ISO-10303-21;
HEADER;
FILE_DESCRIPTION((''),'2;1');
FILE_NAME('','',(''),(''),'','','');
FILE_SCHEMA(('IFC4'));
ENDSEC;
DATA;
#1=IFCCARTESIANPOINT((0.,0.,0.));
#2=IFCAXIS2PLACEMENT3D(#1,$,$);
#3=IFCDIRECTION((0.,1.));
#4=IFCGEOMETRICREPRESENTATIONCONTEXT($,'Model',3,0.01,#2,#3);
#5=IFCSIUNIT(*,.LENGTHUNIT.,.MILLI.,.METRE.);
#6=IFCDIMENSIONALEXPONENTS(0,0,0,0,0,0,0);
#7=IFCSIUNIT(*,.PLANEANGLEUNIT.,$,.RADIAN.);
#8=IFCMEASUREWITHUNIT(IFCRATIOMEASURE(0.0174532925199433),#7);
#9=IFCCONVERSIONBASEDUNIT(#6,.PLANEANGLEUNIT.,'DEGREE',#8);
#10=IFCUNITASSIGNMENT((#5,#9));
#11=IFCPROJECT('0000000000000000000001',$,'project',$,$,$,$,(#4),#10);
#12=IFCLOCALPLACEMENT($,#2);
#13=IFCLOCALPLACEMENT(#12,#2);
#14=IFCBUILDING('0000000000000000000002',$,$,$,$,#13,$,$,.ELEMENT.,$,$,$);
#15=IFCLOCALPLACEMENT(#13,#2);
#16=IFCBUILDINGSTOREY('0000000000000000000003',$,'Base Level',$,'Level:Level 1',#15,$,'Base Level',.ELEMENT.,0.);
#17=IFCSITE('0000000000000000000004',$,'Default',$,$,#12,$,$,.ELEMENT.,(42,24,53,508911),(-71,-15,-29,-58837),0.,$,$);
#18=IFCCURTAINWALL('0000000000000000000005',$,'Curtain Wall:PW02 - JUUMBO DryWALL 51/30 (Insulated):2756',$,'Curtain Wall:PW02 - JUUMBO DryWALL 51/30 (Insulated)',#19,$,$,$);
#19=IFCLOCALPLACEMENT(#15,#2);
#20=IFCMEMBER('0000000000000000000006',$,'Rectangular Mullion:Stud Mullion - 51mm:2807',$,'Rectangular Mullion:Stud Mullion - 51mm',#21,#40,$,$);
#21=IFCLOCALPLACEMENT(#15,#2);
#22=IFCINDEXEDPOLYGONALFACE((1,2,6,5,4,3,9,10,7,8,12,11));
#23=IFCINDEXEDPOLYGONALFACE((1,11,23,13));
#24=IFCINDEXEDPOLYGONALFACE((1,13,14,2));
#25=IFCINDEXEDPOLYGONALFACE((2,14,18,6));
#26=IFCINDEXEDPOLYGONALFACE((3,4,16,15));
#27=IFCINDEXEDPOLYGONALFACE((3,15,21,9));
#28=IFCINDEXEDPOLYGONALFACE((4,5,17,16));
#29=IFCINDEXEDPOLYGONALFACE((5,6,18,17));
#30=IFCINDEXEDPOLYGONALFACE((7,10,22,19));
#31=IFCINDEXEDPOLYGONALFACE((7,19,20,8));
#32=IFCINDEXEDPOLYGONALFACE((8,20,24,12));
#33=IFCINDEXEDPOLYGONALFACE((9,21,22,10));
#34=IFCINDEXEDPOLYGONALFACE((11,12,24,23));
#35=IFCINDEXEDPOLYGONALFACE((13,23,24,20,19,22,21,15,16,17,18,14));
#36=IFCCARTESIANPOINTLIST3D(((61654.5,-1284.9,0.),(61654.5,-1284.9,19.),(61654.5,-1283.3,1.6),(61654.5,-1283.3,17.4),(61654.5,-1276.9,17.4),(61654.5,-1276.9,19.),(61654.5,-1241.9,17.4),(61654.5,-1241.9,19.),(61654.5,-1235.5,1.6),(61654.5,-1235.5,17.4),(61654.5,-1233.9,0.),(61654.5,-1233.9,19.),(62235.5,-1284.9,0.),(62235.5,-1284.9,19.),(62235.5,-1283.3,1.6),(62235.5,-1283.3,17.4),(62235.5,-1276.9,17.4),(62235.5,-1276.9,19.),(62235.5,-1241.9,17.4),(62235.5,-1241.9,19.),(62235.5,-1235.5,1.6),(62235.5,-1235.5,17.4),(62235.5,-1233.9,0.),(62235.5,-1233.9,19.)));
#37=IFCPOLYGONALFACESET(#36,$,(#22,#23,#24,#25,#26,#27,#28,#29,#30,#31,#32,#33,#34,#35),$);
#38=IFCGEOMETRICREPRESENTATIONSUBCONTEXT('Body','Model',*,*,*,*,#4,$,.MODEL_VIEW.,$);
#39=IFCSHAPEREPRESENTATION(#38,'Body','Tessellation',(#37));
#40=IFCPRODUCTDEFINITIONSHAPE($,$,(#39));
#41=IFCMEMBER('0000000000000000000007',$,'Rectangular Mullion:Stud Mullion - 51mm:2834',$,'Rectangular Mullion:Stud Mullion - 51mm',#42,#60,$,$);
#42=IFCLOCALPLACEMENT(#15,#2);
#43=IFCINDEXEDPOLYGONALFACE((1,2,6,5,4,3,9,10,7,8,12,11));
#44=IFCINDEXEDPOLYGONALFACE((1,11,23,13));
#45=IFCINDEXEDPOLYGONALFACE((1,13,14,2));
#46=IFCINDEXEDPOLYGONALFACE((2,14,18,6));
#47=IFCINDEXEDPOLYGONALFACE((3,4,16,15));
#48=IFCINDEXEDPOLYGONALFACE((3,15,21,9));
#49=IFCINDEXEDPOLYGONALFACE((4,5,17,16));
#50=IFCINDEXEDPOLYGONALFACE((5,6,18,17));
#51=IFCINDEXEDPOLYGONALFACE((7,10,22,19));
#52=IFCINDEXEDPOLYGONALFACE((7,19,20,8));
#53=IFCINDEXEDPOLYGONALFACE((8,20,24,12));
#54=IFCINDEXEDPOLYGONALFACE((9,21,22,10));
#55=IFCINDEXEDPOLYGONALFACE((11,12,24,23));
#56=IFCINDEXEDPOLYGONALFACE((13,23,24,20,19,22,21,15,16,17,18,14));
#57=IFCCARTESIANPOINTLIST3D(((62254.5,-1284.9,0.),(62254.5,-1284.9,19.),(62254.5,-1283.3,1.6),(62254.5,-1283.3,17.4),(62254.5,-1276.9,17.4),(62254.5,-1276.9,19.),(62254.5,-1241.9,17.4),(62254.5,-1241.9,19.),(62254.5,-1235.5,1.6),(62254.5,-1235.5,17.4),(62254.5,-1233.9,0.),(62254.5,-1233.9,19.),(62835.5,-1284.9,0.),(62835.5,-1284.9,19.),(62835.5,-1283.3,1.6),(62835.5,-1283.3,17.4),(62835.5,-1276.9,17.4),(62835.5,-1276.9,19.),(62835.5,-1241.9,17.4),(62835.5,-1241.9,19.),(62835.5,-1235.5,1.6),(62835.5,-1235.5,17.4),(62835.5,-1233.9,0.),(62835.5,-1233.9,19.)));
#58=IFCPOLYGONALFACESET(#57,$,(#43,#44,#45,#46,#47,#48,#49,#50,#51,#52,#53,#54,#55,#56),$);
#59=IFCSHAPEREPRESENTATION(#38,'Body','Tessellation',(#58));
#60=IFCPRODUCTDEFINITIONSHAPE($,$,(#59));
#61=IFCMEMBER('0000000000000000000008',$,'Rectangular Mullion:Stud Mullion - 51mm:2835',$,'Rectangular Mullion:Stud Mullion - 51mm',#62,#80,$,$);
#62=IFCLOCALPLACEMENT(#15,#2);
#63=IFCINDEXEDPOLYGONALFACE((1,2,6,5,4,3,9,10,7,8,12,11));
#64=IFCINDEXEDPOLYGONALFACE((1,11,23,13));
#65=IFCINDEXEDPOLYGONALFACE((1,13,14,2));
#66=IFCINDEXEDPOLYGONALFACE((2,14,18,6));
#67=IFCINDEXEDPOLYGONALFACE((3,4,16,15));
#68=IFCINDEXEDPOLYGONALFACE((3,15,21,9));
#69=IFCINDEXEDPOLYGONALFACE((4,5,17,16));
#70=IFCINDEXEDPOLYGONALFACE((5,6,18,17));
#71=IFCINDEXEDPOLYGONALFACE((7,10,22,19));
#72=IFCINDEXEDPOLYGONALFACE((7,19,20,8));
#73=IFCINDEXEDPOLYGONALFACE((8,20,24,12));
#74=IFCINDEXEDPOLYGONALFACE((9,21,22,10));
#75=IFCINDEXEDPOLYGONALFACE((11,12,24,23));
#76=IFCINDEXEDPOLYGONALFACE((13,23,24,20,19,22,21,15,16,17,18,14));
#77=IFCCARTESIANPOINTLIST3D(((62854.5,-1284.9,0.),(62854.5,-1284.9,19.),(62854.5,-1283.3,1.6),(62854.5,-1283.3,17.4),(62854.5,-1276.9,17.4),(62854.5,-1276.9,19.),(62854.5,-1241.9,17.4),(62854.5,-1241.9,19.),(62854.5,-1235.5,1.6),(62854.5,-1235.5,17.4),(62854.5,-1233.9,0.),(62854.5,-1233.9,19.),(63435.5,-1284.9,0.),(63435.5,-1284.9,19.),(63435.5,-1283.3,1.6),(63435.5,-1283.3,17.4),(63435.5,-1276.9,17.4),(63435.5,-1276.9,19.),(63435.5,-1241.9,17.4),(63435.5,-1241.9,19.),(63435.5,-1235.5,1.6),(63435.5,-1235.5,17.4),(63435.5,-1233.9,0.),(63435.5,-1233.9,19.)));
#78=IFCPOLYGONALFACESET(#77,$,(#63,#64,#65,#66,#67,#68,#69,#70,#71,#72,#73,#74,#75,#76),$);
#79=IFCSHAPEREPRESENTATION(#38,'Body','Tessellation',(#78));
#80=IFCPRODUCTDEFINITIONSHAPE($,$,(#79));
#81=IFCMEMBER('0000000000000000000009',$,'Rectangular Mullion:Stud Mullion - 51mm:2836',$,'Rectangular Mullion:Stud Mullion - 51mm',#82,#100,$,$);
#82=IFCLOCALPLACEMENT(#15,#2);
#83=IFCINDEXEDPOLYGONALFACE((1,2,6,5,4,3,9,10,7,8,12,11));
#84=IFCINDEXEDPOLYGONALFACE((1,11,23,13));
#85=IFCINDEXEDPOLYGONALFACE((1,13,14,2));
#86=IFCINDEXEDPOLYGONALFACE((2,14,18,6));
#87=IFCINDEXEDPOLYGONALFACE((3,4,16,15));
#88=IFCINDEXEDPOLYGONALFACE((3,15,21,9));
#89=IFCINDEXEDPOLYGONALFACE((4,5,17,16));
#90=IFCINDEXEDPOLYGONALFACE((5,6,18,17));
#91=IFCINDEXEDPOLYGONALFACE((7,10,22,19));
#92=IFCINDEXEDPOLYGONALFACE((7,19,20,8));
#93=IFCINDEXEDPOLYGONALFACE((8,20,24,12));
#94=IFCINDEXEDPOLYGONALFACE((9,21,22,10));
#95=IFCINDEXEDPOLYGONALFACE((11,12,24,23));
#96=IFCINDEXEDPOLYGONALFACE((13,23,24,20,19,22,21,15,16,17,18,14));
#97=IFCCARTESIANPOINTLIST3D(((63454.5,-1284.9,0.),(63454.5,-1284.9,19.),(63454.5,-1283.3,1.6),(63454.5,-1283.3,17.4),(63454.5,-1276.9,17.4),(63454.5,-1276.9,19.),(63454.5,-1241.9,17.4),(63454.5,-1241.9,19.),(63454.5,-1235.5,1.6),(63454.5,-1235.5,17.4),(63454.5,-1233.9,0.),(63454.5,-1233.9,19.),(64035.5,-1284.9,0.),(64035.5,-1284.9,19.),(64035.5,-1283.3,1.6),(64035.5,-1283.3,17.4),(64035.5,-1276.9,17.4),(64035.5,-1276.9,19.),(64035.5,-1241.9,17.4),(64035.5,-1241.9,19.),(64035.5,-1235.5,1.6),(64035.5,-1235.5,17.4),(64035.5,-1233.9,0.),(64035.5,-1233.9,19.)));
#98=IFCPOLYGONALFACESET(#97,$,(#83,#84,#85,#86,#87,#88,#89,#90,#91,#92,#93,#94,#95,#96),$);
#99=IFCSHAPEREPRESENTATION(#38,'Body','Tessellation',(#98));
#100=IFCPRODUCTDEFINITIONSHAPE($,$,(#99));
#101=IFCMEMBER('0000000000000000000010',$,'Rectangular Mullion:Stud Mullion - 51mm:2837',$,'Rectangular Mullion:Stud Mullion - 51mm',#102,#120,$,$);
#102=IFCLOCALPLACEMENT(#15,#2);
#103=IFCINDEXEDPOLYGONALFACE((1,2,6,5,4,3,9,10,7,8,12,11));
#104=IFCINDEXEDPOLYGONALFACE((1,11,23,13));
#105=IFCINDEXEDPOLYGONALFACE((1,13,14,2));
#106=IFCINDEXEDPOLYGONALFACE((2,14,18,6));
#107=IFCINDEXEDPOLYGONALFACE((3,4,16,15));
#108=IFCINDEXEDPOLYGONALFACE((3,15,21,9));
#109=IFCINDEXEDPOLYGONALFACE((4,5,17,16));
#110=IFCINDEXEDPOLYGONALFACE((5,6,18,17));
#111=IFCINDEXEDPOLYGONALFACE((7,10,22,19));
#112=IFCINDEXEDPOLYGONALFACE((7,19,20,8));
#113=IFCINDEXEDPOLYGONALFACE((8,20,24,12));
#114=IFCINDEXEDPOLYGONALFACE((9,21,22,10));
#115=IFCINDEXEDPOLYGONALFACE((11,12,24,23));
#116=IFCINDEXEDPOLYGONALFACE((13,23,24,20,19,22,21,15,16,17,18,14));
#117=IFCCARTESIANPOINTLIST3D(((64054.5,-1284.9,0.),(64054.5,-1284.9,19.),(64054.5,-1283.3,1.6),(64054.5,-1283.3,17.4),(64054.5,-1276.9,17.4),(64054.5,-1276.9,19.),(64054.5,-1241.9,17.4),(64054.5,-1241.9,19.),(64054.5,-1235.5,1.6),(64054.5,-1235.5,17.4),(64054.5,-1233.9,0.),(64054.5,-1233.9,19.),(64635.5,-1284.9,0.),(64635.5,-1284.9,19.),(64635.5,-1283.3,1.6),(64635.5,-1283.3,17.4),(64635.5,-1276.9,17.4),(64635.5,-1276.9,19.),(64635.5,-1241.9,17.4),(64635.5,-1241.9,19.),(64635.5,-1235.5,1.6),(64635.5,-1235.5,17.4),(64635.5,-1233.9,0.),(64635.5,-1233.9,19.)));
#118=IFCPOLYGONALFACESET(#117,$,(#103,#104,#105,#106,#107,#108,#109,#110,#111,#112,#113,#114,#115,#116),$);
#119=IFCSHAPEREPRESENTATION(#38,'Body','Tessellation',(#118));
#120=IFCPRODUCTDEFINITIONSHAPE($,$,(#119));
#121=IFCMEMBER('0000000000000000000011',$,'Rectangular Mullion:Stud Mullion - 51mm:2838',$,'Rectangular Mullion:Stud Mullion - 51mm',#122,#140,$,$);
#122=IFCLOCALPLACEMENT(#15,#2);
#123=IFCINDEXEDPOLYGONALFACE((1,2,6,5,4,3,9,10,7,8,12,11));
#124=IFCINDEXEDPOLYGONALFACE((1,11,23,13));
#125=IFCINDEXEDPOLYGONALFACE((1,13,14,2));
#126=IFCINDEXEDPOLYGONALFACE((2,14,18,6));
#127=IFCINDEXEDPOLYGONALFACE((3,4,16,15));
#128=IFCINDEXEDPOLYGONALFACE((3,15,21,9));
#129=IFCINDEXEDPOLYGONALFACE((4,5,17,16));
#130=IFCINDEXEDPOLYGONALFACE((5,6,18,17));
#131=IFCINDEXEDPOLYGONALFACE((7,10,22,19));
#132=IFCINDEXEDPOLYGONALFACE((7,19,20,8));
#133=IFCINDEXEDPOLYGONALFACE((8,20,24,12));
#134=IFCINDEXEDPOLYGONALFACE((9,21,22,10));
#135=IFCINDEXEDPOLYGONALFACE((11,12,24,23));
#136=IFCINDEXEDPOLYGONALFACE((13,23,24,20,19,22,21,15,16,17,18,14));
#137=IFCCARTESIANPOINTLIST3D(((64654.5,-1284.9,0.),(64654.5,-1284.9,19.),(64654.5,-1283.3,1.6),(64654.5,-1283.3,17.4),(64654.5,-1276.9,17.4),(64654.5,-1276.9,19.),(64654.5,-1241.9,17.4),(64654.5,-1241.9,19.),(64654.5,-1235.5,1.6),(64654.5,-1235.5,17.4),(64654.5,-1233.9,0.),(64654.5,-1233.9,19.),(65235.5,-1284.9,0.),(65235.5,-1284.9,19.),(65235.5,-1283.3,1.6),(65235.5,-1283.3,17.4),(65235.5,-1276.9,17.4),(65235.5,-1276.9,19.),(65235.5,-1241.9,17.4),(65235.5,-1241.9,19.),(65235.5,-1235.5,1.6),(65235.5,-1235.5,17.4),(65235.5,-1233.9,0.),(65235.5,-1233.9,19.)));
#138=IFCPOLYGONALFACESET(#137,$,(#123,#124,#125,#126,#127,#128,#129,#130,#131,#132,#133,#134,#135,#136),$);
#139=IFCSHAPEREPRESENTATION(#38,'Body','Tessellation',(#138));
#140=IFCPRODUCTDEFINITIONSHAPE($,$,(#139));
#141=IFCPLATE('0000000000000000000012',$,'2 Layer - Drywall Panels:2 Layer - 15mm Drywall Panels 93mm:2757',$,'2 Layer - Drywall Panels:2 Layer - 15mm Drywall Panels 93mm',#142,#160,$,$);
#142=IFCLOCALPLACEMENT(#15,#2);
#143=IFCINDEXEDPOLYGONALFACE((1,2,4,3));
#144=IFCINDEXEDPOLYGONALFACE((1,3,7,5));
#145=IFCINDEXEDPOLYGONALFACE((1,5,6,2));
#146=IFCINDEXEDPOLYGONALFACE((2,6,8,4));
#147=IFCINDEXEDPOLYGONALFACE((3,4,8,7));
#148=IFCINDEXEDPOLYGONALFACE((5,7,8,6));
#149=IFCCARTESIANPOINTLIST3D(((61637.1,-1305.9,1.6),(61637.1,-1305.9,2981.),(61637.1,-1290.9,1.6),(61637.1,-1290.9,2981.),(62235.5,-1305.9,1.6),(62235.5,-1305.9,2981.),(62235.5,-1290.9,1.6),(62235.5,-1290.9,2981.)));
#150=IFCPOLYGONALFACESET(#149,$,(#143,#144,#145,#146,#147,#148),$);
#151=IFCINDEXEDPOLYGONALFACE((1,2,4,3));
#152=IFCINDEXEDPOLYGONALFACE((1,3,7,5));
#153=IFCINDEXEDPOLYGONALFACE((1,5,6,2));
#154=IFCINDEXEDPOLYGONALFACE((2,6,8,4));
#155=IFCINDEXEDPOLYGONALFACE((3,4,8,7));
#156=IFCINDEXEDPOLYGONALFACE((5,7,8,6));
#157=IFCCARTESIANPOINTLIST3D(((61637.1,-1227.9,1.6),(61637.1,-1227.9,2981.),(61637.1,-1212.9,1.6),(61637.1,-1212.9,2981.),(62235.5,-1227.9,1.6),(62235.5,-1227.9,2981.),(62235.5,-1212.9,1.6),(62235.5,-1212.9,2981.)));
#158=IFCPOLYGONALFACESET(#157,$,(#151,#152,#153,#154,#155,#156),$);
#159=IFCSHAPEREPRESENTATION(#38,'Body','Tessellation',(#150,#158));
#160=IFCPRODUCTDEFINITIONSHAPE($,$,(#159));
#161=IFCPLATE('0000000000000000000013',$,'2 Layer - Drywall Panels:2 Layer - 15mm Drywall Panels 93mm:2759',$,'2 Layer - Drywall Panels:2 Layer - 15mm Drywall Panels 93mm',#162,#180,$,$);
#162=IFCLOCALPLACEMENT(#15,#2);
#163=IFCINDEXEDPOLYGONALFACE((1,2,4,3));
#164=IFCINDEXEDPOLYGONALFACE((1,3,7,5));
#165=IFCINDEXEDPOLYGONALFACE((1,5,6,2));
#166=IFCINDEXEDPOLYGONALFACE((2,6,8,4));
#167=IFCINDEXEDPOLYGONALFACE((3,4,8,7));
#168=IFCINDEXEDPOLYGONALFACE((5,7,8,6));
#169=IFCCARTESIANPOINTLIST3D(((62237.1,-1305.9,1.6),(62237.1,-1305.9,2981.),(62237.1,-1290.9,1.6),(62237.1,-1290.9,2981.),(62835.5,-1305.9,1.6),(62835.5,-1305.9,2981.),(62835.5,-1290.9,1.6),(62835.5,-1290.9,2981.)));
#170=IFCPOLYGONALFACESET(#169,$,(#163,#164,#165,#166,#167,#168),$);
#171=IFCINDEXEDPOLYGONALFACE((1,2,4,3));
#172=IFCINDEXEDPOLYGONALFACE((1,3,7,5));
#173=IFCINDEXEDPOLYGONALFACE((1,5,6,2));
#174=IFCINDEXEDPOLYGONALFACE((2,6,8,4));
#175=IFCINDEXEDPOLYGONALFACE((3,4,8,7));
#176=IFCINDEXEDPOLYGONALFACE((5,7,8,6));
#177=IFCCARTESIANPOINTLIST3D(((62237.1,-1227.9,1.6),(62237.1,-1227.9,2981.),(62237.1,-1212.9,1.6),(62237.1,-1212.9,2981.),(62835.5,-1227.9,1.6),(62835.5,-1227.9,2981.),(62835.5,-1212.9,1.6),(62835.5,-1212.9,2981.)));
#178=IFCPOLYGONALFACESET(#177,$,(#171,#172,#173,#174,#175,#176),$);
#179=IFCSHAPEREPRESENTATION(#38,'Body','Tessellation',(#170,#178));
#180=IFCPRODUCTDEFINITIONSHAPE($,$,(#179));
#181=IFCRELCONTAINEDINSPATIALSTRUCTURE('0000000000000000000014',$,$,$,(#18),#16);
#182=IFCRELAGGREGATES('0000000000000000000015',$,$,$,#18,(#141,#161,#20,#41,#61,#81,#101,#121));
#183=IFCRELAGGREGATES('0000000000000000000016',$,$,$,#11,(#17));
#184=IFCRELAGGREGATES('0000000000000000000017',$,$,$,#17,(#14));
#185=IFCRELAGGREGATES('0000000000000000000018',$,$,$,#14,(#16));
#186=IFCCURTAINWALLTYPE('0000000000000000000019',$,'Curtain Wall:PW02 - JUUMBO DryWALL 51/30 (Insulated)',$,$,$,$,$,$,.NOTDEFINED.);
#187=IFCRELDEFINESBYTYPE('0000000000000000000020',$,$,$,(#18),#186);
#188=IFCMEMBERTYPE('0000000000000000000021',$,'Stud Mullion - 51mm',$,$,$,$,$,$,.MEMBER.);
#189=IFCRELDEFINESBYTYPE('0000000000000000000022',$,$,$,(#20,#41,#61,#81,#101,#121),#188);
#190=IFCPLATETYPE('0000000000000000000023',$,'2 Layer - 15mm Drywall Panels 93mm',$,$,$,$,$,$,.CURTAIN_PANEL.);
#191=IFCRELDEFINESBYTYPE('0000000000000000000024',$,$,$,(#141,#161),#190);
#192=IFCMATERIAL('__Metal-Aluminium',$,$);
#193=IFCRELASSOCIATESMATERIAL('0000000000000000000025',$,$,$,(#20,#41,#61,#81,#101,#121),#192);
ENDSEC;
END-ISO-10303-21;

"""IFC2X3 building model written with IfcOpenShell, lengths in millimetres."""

from ifc_helpers import new_model, entity, si_unit, converted_unit, direction, frame, frame_2d, origin, place, context, subcontext, project, spatial, polyline, rectangle, outline, extrude, source, transform, mapped, material, type_object, type_shapes, element, aggregate, save


model = new_model("IFC2X3")

# Units and contexts
model_context = context("Model", 3, precision=0.01, world=origin(), true_north=direction((0.0, 1.0)))
body_context = subcontext(model_context, "Body", "Model", "MODEL_VIEW")
ifc_project = project(units=[si_unit("LENGTHUNIT", "METRE", prefix="MILLI"), converted_unit("PLANEANGLEUNIT", "DEGREE", entity("IfcRatioMeasure", 0.0174532925199433), si_unit("PLANEANGLEUNIT", "RADIAN"), dimensions=[0, 0, 0, 0, 0, 0, 0])], contexts=[model_context])

# Site, building, storey
site_placement = place(None, origin())
site = spatial("IfcSite", under=ifc_project, at=site_placement, Name="Default", CompositionType="ELEMENT", RefLatitude=(42, 24, 53, 508911), RefLongitude=(-71, -15, -29, -58837), RefElevation=0.0)
building_placement = place(site_placement, origin())
building = spatial("IfcBuilding", under=site, at=building_placement, CompositionType="ELEMENT")
storey_placement = place(building_placement, origin())
storey = spatial("IfcBuildingStorey", under=building, at=storey_placement, Name="Base Level", ObjectType="Level:Level 1", LongName="Base Level", CompositionType="ELEMENT", Elevation=0.0)

# Curtain wall, members, plates
curtain_wall_type = type_object("IfcCurtainWallType", Name="Curtain Wall:PW02 - JUUMBO DryWALL 51/30 (Insulated)", PredefinedType="NOTDEFINED")
curtain_wall_placement = place(building_placement, origin())
curtain_wall = element("IfcCurtainWall", 1, at=curtain_wall_placement, inside=storey, type_object=curtain_wall_type, Name="Curtain Wall:PW02 - JUUMBO DryWALL 51/30 (Insulated):2756", ObjectType="Curtain Wall:PW02 - JUUMBO DryWALL 51/30 (Insulated)")
ifc_material_1 = material(Name="__Metal-Aluminium")
member_type_1 = type_object("IfcMemberType", Name="Stud Mullion - 51mm", PredefinedType="MEMBER")
shared_shape_1 = source(origin(), body_context, "Body", "SweptSolid", [
    extrude(outline(polyline([(17.5, -6.6), (25.5, -6.6), (25.5, 12.4), (-25.5, 12.4), (-25.5, -6.6), (-17.5, -6.6), (-17.5, -5.0), (-23.9, -5.0), (-23.9, 10.8), (23.9, 10.8), (23.9, -5.0), (17.5, -5.0), (17.5, -6.6)])), frame((-12.4, 0.0, -581.0), z_axis=(0.0, 0.0, 1.0), x_axis=(0.0, -1.0, 0.0)), (0.0, 0.0, 1.0), 581.0),
])
type_shapes(member_type_1, [shared_shape_1])
member_1_placement = place(building_placement, frame((61654.5, -1259.4, 0.0), z_axis=(-1.0, 0.0, 0.0), x_axis=(0.0, 0.0, -1.0)))
member_1 = element("IfcMember", 2, at=member_1_placement, type_object=member_type_1, material=ifc_material_1, Name="Rectangular Mullion:Stud Mullion - 51mm:2807", ObjectType="Rectangular Mullion:Stud Mullion - 51mm", context=body_context, shape_type="MappedRepresentation", body=[
    mapped(shared_shape_1, transform((0.0, 0.0, 0.0), scale=1.0)),
])
member_2_placement = place(building_placement, frame((62254.5, -1259.4, 0.0), z_axis=(-1.0, 0.0, 0.0), x_axis=(0.0, 0.0, -1.0)))
member_2 = element("IfcMember", 3, at=member_2_placement, type_object=member_type_1, material=ifc_material_1, Name="Rectangular Mullion:Stud Mullion - 51mm:2834", ObjectType="Rectangular Mullion:Stud Mullion - 51mm", context=body_context, shape_type="MappedRepresentation", body=[
    mapped(shared_shape_1, transform((0.0, 0.0, 0.0), scale=1.0)),
])
member_3_placement = place(building_placement, frame((62854.5, -1259.4, 0.0), z_axis=(-1.0, 0.0, 0.0), x_axis=(0.0, 0.0, -1.0)))
member_3 = element("IfcMember", 4, at=member_3_placement, type_object=member_type_1, material=ifc_material_1, Name="Rectangular Mullion:Stud Mullion - 51mm:2835", ObjectType="Rectangular Mullion:Stud Mullion - 51mm", context=body_context, shape_type="MappedRepresentation", body=[
    mapped(shared_shape_1, transform((0.0, 0.0, 0.0), scale=1.0)),
])
member_4_placement = place(building_placement, frame((63454.5, -1259.4, 0.0), z_axis=(-1.0, 0.0, 0.0), x_axis=(0.0, 0.0, -1.0)))
member_4 = element("IfcMember", 5, at=member_4_placement, type_object=member_type_1, material=ifc_material_1, Name="Rectangular Mullion:Stud Mullion - 51mm:2836", ObjectType="Rectangular Mullion:Stud Mullion - 51mm", context=body_context, shape_type="MappedRepresentation", body=[
    mapped(shared_shape_1, transform((0.0, 0.0, 0.0), scale=1.0)),
])
member_5_placement = place(building_placement, frame((64054.5, -1259.4, 0.0), z_axis=(-1.0, 0.0, 0.0), x_axis=(0.0, 0.0, -1.0)))
member_5 = element("IfcMember", 6, at=member_5_placement, type_object=member_type_1, material=ifc_material_1, Name="Rectangular Mullion:Stud Mullion - 51mm:2837", ObjectType="Rectangular Mullion:Stud Mullion - 51mm", context=body_context, shape_type="MappedRepresentation", body=[
    mapped(shared_shape_1, transform((0.0, 0.0, 0.0), scale=1.0)),
])
member_6_placement = place(building_placement, frame((64654.5, -1259.4, 0.0), z_axis=(-1.0, 0.0, 0.0), x_axis=(0.0, 0.0, -1.0)))
member_6 = element("IfcMember", 7, at=member_6_placement, type_object=member_type_1, material=ifc_material_1, Name="Rectangular Mullion:Stud Mullion - 51mm:2838", ObjectType="Rectangular Mullion:Stud Mullion - 51mm", context=body_context, shape_type="MappedRepresentation", body=[
    mapped(shared_shape_1, transform((0.0, 0.0, 0.0), scale=1.0)),
])
plate_type_1 = type_object("IfcPlateType", Name="2 Layer - 15mm Drywall Panels 93mm", PredefinedType="CURTAIN_PANEL")
shared_shape_2 = source(origin(), body_context, "Body", "SweptSolid", [
    extrude(rectangle(XDim=598.4, YDim=15.0, at=frame_2d((0.0, 0.0), x_axis=(1.0, 0.0))), frame((0.0, -39.0, 0.0), z_axis=(0.0, 0.0, 1.0), x_axis=(-1.0, 0.0, 0.0)), (0.0, 0.0, 1.0), 2979.4),
    extrude(rectangle(XDim=15.0, YDim=598.4, at=frame_2d((0.0, 0.0), x_axis=(1.0, 0.0))), frame((0.0, 39.0, 0.0), z_axis=(0.0, 0.0, 1.0), x_axis=(0.0, 1.0, 0.0)), (0.0, 0.0, 1.0), 2979.4),
])
type_shapes(plate_type_1, [shared_shape_2])
plate_1_placement = place(curtain_wall_placement, frame((61936.3, -1259.4, 1.6)))
plate_1 = element("IfcPlate", 8, at=plate_1_placement, type_object=plate_type_1, Name="2 Layer - Drywall Panels:2 Layer - 15mm Drywall Panels 93mm:2757", ObjectType="2 Layer - Drywall Panels:2 Layer - 15mm Drywall Panels 93mm", context=body_context, shape_type="MappedRepresentation", body=[
    mapped(shared_shape_2, transform((0.0, 0.0, 0.0), scale=1.0)),
])
plate_2_placement = place(curtain_wall_placement, frame((62536.3, -1259.4, 1.6)))
plate_2 = element("IfcPlate", 9, at=plate_2_placement, type_object=plate_type_1, Name="2 Layer - Drywall Panels:2 Layer - 15mm Drywall Panels 93mm:2759", ObjectType="2 Layer - Drywall Panels:2 Layer - 15mm Drywall Panels 93mm", context=body_context, shape_type="MappedRepresentation", body=[
    mapped(shared_shape_2, transform((0.0, 0.0, 0.0), scale=1.0)),
])
aggregate(curtain_wall, [plate_1, plate_2, member_1, member_2, member_3, member_4, member_5, member_6])

save(model, "model.ifc")
